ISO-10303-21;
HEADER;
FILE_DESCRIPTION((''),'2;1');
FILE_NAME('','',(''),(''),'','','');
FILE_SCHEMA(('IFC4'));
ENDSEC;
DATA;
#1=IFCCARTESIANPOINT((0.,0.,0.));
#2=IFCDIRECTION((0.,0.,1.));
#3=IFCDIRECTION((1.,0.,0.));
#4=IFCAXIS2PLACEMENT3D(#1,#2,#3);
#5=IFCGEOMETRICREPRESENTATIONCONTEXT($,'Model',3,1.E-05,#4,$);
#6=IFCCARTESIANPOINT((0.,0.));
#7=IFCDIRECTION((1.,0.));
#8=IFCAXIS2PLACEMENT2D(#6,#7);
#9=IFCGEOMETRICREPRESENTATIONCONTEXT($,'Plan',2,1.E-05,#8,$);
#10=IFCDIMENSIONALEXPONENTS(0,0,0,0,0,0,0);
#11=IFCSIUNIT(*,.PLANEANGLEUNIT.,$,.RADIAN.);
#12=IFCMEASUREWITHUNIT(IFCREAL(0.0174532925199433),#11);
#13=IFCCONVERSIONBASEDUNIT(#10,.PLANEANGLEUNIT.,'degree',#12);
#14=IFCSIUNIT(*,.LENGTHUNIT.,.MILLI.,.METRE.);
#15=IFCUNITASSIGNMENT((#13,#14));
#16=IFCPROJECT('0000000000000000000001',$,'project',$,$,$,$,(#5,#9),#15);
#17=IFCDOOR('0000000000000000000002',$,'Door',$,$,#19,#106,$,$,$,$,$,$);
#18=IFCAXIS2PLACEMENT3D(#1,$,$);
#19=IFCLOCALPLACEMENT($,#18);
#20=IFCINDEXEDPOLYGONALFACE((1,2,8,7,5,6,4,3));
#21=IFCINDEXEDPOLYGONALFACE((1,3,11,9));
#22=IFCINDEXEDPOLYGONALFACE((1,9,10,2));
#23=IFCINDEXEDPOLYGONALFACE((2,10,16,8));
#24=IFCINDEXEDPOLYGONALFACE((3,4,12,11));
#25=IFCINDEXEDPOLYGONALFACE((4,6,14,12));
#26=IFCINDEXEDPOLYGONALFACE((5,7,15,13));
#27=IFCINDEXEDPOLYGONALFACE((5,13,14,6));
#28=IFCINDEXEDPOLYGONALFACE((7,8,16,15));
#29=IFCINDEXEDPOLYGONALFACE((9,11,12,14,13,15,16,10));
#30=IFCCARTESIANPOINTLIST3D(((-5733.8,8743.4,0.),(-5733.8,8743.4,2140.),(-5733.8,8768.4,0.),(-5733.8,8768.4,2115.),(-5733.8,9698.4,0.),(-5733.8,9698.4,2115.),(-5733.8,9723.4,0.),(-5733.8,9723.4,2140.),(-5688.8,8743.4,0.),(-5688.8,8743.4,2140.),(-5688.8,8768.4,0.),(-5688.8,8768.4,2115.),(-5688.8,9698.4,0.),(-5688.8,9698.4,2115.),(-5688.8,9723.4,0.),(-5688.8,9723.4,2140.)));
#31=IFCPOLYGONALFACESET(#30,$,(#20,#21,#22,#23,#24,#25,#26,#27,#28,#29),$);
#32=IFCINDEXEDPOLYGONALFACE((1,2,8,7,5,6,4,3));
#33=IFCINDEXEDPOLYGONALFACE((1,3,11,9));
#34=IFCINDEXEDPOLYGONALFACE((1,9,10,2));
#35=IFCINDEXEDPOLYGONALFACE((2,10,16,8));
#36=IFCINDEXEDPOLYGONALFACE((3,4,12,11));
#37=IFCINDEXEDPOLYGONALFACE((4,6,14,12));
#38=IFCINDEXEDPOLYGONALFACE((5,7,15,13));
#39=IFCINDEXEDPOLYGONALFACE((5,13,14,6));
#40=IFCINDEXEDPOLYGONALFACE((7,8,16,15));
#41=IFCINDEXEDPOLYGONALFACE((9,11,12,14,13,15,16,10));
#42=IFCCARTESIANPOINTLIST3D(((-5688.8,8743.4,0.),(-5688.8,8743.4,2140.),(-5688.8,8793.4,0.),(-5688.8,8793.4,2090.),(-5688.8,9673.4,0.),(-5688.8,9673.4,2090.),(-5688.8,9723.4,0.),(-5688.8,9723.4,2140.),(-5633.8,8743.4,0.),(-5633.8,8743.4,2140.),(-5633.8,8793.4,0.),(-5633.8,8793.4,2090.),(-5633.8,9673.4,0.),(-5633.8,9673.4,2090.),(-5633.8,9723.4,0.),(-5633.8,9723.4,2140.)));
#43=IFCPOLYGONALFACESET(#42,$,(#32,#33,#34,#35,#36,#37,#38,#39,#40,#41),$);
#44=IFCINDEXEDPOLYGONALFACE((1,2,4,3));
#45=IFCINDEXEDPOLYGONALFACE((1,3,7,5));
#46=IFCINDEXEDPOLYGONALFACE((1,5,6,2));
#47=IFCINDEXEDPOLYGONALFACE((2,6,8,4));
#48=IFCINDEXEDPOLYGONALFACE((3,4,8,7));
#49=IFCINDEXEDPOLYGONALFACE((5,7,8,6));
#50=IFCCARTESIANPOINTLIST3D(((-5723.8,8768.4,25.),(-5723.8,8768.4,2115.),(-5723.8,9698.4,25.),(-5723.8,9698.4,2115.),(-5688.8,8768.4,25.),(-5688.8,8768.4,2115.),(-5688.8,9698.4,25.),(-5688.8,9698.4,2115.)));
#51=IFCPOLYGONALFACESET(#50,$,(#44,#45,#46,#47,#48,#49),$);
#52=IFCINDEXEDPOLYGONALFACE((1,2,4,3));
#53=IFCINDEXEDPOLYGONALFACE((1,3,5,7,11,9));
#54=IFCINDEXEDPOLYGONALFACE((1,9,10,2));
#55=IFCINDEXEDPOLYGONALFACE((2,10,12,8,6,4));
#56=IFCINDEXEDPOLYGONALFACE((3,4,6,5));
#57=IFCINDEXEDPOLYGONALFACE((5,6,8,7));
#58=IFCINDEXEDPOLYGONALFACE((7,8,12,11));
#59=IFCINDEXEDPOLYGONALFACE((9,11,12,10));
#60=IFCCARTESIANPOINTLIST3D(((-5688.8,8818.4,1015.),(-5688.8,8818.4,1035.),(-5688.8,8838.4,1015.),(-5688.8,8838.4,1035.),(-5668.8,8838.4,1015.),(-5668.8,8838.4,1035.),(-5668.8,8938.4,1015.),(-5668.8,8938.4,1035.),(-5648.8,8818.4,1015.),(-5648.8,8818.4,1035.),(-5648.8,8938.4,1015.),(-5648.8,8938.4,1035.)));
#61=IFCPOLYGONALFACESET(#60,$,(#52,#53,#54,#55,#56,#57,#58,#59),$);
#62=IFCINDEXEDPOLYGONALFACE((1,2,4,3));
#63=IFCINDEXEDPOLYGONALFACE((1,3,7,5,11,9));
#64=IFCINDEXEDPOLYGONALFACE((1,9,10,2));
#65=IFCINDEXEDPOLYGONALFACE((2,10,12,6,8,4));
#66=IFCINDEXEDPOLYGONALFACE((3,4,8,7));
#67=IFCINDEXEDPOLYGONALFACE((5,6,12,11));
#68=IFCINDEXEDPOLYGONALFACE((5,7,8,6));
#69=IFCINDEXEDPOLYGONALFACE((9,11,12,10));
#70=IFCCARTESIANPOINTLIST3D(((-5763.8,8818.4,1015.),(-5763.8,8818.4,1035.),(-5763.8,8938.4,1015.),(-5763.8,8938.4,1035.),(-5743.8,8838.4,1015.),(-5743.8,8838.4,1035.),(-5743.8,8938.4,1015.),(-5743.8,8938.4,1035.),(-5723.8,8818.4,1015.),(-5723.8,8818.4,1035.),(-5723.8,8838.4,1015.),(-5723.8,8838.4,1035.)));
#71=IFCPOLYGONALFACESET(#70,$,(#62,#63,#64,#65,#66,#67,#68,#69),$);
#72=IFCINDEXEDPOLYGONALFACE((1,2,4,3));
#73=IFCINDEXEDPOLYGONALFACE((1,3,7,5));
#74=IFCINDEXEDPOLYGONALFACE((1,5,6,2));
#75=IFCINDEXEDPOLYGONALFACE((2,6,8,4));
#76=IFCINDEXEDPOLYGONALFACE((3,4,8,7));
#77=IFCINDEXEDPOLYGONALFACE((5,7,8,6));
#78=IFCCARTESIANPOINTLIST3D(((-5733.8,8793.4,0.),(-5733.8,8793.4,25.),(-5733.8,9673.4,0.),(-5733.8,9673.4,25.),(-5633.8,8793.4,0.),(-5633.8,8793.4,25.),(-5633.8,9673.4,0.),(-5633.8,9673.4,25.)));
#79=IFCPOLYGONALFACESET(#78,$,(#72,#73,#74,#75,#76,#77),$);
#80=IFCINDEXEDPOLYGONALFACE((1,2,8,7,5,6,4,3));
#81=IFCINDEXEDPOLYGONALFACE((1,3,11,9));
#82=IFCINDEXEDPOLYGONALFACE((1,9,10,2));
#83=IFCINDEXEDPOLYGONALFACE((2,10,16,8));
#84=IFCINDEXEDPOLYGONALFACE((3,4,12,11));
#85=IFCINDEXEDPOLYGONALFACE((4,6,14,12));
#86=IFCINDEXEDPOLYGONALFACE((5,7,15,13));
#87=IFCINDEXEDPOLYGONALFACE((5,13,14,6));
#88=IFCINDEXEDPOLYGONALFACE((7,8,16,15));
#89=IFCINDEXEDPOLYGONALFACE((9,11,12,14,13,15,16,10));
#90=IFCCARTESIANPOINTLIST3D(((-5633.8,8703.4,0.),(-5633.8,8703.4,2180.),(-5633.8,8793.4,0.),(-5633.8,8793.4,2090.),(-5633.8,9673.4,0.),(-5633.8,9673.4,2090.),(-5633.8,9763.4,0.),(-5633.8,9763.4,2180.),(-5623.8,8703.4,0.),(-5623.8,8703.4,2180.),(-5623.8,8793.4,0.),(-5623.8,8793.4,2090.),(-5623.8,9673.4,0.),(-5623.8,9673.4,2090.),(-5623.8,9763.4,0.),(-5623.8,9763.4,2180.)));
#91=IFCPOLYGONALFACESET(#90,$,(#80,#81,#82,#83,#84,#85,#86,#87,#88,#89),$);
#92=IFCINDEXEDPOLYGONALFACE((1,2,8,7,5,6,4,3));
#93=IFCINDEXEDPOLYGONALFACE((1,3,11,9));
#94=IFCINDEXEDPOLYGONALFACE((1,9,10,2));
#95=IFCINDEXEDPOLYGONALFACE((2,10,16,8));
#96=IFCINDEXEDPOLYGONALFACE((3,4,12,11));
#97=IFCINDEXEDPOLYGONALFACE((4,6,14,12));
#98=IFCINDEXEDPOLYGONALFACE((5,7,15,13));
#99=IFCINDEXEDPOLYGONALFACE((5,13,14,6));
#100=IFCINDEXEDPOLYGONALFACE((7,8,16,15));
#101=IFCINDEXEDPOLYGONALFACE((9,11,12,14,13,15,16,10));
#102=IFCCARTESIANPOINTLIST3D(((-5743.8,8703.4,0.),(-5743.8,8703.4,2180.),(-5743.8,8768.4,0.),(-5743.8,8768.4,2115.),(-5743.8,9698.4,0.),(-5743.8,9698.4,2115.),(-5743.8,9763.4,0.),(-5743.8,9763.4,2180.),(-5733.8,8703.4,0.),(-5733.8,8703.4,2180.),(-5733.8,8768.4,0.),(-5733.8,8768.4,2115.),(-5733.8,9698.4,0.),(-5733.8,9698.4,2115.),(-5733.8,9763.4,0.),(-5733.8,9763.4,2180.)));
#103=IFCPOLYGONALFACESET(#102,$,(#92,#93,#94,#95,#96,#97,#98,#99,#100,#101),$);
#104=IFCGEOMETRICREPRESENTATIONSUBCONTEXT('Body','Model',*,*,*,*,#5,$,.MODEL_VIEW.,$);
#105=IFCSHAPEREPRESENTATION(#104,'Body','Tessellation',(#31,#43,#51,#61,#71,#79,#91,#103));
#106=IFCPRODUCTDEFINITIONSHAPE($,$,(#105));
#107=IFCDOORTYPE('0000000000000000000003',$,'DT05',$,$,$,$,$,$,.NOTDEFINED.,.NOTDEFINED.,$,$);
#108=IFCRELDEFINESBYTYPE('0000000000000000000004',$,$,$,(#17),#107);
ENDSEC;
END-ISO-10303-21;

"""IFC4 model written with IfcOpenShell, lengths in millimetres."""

from ifc_helpers import new_model, entity, si_unit, converted_unit, frame, origin_with_axes, origin_2d_with_axis, place, context, subcontext, project, line, indexed_curve, outline, extrude, shape, source, transform, mapped, type_object, type_shapes, element, save


model = new_model("IFC4")

# Units and contexts
model_context = context("Model", 3, precision=1e-05, world=origin_with_axes())
plan_context = context("Plan", 2, precision=1e-05, world=origin_2d_with_axis())
body_context_1 = subcontext(model_context, "Body", "Model", "MODEL_VIEW")
body_context_2 = subcontext(plan_context, "Body", "Plan", "PLAN_VIEW")
ifc_project = project(units=[converted_unit("PLANEANGLEUNIT", "degree", entity("IfcReal", 0.0174532925199433), si_unit("PLANEANGLEUNIT", "RADIAN"), dimensions=[0, 0, 0, 0, 0, 0, 0]), si_unit("LENGTHUNIT", "METRE", prefix="MILLI")], contexts=[model_context, plan_context])

# Door
door_type = type_object("IfcDoorType", Name="DT05", OperationType="NOTDEFINED", PredefinedType="NOTDEFINED")
shared_shape_1 = source(origin_with_axes(), body_context_1, "Body", "SweptSolid", [
    extrude(outline(indexed_curve([(0.0, 0.0), (0.0, 2140.0), (980.0, 2140.0), (980.0, 0.0), (955.0, 0.0), (955.0, 2115.0), (25.0, 2115.0), (25.0, 0.0)], segments=[line(1, 2, 3, 4, 5, 6, 7, 8, 1)])), frame((0.0, 55.0, 0.0), z_axis=(0.0, -1.0, 0.0), x_axis=(1.0, 0.0, 0.0)), (0.0, 0.0, -1.0), 45.0),
    extrude(outline(indexed_curve([(0.0, 0.0), (0.0, 2140.0), (980.0, 2140.0), (980.0, 0.0), (930.0, 0.0), (930.0, 2090.0), (50.0, 2090.0), (50.0, 0.0)], segments=[line(1, 2, 3, 4, 5, 6, 7, 8, 1)])), frame((0.0, 0.0, 0.0), z_axis=(0.0, -1.0, 0.0), x_axis=(1.0, 0.0, 0.0)), (0.0, 0.0, -1.0), 55.0),
    extrude(outline(indexed_curve([(0.0, 0.0), (930.0, 0.0), (930.0, 35.0), (0.0, 35.0)], segments=[line(1, 2, 3, 4, 1)])), frame((25.0, 55.0, 25.0), z_axis=(0.0, 0.0, 1.0), x_axis=(1.0, 0.0, 0.0)), (0.0, 0.0, 1.0), 2090.0),
    extrude(outline(indexed_curve([(0.0, 0.0), (0.0, -40.0), (120.0, -40.0), (120.0, -20.0), (20.0, -20.0), (20.0, 0.0)], segments=[line(1, 2, 3, 4, 5, 6, 1)])), frame((75.0, 55.0, 1015.0), z_axis=(0.0, 0.0, 1.0), x_axis=(1.0, 0.0, 0.0)), (0.0, 0.0, 1.0), 20.0),
    extrude(outline(indexed_curve([(0.0, 0.0), (0.0, 40.0), (120.0, 40.0), (120.0, 20.0), (20.0, 20.0), (20.0, 0.0)], segments=[line(1, 2, 3, 4, 5, 6, 1)])), frame((75.0, 90.0, 1015.0), z_axis=(0.0, 0.0, 1.0), x_axis=(1.0, 0.0, 0.0)), (0.0, 0.0, 1.0), 20.0),
    extrude(outline(indexed_curve([(0.0, 0.0), (880.0, 0.0), (880.0, 100.0), (0.0, 100.0)], segments=[line(1, 2, 3, 4, 1)])), frame((50.0, 0.0, 0.0), z_axis=(0.0, 0.0, 1.0), x_axis=(1.0, 0.0, 0.0)), (0.0, 0.0, 1.0), 25.0),
    extrude(outline(indexed_curve([(0.0, 0.0), (0.0, 2180.0), (1060.0, 2180.0), (1060.0, 0.0), (970.0, 0.0), (970.0, 2090.0), (90.0, 2090.0), (90.0, 0.0)], segments=[line(1, 2, 3, 4, 5, 6, 7, 8, 1)])), frame((-40.0, -10.0, 0.0), z_axis=(0.0, -1.0, 0.0), x_axis=(1.0, 0.0, 0.0)), (0.0, 0.0, -1.0), 10.0),
    extrude(outline(indexed_curve([(0.0, 0.0), (0.0, 2180.0), (1060.0, 2180.0), (1060.0, 0.0), (995.0, 0.0), (995.0, 2115.0), (65.0, 2115.0), (65.0, 0.0)], segments=[line(1, 2, 3, 4, 5, 6, 7, 8, 1)])), frame((-40.0, 100.0, 0.0), z_axis=(0.0, -1.0, 0.0), x_axis=(1.0, 0.0, 0.0)), (0.0, 0.0, -1.0), 10.0),
])
shared_shape_2 = source(origin_with_axes(), body_context_2, "Body", "Curve2D", [
    entity("IfcIndexedPolyCurve", entity("IfcCartesianPointList2D", [[0.0, 0.0], [0.0, 100.0], [25.0, 100.0], [25.0, 55.0], [50.0, 55.0], [50.0, 0.0]]), [entity("IfcLineIndex", [1, 2, 3, 4, 5, 6, 1])]),
    entity("IfcIndexedPolyCurve", entity("IfcCartesianPointList2D", [[980.0, 0.0], [980.0, 100.0], [955.0, 100.0], [955.0, 55.0], [930.0, 55.0], [930.0, 0.0]]), [entity("IfcLineIndex", [1, 2, 3, 4, 5, 6, 1])]),
    entity("IfcTrimmedCurve", entity("IfcEllipse", entity("IfcAxis2Placement2D", entity("IfcCartesianPoint", [920.0, 100.0]), entity("IfcDirection", [1.0, 0.0])), 895.0, 930.0), [entity("IfcCartesianPoint", [920.0, 1030.0])], [entity("IfcCartesianPoint", [25.0, 100.0])], True, "CARTESIAN"),
    entity("IfcIndexedPolyCurve", entity("IfcCartesianPointList2D", [[955.0, 100.0], [920.0, 100.0], [920.0, 1030.0], [955.0, 1030.0]]), [entity("IfcLineIndex", [1, 2, 3, 4, 1])]),
])
type_shapes(door_type, [shared_shape_1, shared_shape_2])
door_placement = place(None, frame((-5633.8, 8743.4, 0.0), z_axis=(0.0, 0.0, 1.0), x_axis=(0.0, 1.0, 0.0)))
element("IfcDoor", 1, at=door_placement, type_object=door_type, Name="Door", shapes=[
    shape(body_context_1, "Body", "MappedRepresentation", [mapped(shared_shape_1, transform((0.0, 0.0, 0.0), x_axis=(1.0, 0.0, 0.0), y_axis=(0.0, 1.0, 0.0), z_axis=(0.0, 0.0, 1.0), scale=1.0))]),
    shape(body_context_2, "Body", "MappedRepresentation", [mapped(shared_shape_2, transform((0.0, 0.0, 0.0), x_axis=(1.0, 0.0, 0.0), y_axis=(0.0, 1.0, 0.0), z_axis=(0.0, 0.0, 1.0), scale=1.0))]),
])

save(model, "model.ifc")
